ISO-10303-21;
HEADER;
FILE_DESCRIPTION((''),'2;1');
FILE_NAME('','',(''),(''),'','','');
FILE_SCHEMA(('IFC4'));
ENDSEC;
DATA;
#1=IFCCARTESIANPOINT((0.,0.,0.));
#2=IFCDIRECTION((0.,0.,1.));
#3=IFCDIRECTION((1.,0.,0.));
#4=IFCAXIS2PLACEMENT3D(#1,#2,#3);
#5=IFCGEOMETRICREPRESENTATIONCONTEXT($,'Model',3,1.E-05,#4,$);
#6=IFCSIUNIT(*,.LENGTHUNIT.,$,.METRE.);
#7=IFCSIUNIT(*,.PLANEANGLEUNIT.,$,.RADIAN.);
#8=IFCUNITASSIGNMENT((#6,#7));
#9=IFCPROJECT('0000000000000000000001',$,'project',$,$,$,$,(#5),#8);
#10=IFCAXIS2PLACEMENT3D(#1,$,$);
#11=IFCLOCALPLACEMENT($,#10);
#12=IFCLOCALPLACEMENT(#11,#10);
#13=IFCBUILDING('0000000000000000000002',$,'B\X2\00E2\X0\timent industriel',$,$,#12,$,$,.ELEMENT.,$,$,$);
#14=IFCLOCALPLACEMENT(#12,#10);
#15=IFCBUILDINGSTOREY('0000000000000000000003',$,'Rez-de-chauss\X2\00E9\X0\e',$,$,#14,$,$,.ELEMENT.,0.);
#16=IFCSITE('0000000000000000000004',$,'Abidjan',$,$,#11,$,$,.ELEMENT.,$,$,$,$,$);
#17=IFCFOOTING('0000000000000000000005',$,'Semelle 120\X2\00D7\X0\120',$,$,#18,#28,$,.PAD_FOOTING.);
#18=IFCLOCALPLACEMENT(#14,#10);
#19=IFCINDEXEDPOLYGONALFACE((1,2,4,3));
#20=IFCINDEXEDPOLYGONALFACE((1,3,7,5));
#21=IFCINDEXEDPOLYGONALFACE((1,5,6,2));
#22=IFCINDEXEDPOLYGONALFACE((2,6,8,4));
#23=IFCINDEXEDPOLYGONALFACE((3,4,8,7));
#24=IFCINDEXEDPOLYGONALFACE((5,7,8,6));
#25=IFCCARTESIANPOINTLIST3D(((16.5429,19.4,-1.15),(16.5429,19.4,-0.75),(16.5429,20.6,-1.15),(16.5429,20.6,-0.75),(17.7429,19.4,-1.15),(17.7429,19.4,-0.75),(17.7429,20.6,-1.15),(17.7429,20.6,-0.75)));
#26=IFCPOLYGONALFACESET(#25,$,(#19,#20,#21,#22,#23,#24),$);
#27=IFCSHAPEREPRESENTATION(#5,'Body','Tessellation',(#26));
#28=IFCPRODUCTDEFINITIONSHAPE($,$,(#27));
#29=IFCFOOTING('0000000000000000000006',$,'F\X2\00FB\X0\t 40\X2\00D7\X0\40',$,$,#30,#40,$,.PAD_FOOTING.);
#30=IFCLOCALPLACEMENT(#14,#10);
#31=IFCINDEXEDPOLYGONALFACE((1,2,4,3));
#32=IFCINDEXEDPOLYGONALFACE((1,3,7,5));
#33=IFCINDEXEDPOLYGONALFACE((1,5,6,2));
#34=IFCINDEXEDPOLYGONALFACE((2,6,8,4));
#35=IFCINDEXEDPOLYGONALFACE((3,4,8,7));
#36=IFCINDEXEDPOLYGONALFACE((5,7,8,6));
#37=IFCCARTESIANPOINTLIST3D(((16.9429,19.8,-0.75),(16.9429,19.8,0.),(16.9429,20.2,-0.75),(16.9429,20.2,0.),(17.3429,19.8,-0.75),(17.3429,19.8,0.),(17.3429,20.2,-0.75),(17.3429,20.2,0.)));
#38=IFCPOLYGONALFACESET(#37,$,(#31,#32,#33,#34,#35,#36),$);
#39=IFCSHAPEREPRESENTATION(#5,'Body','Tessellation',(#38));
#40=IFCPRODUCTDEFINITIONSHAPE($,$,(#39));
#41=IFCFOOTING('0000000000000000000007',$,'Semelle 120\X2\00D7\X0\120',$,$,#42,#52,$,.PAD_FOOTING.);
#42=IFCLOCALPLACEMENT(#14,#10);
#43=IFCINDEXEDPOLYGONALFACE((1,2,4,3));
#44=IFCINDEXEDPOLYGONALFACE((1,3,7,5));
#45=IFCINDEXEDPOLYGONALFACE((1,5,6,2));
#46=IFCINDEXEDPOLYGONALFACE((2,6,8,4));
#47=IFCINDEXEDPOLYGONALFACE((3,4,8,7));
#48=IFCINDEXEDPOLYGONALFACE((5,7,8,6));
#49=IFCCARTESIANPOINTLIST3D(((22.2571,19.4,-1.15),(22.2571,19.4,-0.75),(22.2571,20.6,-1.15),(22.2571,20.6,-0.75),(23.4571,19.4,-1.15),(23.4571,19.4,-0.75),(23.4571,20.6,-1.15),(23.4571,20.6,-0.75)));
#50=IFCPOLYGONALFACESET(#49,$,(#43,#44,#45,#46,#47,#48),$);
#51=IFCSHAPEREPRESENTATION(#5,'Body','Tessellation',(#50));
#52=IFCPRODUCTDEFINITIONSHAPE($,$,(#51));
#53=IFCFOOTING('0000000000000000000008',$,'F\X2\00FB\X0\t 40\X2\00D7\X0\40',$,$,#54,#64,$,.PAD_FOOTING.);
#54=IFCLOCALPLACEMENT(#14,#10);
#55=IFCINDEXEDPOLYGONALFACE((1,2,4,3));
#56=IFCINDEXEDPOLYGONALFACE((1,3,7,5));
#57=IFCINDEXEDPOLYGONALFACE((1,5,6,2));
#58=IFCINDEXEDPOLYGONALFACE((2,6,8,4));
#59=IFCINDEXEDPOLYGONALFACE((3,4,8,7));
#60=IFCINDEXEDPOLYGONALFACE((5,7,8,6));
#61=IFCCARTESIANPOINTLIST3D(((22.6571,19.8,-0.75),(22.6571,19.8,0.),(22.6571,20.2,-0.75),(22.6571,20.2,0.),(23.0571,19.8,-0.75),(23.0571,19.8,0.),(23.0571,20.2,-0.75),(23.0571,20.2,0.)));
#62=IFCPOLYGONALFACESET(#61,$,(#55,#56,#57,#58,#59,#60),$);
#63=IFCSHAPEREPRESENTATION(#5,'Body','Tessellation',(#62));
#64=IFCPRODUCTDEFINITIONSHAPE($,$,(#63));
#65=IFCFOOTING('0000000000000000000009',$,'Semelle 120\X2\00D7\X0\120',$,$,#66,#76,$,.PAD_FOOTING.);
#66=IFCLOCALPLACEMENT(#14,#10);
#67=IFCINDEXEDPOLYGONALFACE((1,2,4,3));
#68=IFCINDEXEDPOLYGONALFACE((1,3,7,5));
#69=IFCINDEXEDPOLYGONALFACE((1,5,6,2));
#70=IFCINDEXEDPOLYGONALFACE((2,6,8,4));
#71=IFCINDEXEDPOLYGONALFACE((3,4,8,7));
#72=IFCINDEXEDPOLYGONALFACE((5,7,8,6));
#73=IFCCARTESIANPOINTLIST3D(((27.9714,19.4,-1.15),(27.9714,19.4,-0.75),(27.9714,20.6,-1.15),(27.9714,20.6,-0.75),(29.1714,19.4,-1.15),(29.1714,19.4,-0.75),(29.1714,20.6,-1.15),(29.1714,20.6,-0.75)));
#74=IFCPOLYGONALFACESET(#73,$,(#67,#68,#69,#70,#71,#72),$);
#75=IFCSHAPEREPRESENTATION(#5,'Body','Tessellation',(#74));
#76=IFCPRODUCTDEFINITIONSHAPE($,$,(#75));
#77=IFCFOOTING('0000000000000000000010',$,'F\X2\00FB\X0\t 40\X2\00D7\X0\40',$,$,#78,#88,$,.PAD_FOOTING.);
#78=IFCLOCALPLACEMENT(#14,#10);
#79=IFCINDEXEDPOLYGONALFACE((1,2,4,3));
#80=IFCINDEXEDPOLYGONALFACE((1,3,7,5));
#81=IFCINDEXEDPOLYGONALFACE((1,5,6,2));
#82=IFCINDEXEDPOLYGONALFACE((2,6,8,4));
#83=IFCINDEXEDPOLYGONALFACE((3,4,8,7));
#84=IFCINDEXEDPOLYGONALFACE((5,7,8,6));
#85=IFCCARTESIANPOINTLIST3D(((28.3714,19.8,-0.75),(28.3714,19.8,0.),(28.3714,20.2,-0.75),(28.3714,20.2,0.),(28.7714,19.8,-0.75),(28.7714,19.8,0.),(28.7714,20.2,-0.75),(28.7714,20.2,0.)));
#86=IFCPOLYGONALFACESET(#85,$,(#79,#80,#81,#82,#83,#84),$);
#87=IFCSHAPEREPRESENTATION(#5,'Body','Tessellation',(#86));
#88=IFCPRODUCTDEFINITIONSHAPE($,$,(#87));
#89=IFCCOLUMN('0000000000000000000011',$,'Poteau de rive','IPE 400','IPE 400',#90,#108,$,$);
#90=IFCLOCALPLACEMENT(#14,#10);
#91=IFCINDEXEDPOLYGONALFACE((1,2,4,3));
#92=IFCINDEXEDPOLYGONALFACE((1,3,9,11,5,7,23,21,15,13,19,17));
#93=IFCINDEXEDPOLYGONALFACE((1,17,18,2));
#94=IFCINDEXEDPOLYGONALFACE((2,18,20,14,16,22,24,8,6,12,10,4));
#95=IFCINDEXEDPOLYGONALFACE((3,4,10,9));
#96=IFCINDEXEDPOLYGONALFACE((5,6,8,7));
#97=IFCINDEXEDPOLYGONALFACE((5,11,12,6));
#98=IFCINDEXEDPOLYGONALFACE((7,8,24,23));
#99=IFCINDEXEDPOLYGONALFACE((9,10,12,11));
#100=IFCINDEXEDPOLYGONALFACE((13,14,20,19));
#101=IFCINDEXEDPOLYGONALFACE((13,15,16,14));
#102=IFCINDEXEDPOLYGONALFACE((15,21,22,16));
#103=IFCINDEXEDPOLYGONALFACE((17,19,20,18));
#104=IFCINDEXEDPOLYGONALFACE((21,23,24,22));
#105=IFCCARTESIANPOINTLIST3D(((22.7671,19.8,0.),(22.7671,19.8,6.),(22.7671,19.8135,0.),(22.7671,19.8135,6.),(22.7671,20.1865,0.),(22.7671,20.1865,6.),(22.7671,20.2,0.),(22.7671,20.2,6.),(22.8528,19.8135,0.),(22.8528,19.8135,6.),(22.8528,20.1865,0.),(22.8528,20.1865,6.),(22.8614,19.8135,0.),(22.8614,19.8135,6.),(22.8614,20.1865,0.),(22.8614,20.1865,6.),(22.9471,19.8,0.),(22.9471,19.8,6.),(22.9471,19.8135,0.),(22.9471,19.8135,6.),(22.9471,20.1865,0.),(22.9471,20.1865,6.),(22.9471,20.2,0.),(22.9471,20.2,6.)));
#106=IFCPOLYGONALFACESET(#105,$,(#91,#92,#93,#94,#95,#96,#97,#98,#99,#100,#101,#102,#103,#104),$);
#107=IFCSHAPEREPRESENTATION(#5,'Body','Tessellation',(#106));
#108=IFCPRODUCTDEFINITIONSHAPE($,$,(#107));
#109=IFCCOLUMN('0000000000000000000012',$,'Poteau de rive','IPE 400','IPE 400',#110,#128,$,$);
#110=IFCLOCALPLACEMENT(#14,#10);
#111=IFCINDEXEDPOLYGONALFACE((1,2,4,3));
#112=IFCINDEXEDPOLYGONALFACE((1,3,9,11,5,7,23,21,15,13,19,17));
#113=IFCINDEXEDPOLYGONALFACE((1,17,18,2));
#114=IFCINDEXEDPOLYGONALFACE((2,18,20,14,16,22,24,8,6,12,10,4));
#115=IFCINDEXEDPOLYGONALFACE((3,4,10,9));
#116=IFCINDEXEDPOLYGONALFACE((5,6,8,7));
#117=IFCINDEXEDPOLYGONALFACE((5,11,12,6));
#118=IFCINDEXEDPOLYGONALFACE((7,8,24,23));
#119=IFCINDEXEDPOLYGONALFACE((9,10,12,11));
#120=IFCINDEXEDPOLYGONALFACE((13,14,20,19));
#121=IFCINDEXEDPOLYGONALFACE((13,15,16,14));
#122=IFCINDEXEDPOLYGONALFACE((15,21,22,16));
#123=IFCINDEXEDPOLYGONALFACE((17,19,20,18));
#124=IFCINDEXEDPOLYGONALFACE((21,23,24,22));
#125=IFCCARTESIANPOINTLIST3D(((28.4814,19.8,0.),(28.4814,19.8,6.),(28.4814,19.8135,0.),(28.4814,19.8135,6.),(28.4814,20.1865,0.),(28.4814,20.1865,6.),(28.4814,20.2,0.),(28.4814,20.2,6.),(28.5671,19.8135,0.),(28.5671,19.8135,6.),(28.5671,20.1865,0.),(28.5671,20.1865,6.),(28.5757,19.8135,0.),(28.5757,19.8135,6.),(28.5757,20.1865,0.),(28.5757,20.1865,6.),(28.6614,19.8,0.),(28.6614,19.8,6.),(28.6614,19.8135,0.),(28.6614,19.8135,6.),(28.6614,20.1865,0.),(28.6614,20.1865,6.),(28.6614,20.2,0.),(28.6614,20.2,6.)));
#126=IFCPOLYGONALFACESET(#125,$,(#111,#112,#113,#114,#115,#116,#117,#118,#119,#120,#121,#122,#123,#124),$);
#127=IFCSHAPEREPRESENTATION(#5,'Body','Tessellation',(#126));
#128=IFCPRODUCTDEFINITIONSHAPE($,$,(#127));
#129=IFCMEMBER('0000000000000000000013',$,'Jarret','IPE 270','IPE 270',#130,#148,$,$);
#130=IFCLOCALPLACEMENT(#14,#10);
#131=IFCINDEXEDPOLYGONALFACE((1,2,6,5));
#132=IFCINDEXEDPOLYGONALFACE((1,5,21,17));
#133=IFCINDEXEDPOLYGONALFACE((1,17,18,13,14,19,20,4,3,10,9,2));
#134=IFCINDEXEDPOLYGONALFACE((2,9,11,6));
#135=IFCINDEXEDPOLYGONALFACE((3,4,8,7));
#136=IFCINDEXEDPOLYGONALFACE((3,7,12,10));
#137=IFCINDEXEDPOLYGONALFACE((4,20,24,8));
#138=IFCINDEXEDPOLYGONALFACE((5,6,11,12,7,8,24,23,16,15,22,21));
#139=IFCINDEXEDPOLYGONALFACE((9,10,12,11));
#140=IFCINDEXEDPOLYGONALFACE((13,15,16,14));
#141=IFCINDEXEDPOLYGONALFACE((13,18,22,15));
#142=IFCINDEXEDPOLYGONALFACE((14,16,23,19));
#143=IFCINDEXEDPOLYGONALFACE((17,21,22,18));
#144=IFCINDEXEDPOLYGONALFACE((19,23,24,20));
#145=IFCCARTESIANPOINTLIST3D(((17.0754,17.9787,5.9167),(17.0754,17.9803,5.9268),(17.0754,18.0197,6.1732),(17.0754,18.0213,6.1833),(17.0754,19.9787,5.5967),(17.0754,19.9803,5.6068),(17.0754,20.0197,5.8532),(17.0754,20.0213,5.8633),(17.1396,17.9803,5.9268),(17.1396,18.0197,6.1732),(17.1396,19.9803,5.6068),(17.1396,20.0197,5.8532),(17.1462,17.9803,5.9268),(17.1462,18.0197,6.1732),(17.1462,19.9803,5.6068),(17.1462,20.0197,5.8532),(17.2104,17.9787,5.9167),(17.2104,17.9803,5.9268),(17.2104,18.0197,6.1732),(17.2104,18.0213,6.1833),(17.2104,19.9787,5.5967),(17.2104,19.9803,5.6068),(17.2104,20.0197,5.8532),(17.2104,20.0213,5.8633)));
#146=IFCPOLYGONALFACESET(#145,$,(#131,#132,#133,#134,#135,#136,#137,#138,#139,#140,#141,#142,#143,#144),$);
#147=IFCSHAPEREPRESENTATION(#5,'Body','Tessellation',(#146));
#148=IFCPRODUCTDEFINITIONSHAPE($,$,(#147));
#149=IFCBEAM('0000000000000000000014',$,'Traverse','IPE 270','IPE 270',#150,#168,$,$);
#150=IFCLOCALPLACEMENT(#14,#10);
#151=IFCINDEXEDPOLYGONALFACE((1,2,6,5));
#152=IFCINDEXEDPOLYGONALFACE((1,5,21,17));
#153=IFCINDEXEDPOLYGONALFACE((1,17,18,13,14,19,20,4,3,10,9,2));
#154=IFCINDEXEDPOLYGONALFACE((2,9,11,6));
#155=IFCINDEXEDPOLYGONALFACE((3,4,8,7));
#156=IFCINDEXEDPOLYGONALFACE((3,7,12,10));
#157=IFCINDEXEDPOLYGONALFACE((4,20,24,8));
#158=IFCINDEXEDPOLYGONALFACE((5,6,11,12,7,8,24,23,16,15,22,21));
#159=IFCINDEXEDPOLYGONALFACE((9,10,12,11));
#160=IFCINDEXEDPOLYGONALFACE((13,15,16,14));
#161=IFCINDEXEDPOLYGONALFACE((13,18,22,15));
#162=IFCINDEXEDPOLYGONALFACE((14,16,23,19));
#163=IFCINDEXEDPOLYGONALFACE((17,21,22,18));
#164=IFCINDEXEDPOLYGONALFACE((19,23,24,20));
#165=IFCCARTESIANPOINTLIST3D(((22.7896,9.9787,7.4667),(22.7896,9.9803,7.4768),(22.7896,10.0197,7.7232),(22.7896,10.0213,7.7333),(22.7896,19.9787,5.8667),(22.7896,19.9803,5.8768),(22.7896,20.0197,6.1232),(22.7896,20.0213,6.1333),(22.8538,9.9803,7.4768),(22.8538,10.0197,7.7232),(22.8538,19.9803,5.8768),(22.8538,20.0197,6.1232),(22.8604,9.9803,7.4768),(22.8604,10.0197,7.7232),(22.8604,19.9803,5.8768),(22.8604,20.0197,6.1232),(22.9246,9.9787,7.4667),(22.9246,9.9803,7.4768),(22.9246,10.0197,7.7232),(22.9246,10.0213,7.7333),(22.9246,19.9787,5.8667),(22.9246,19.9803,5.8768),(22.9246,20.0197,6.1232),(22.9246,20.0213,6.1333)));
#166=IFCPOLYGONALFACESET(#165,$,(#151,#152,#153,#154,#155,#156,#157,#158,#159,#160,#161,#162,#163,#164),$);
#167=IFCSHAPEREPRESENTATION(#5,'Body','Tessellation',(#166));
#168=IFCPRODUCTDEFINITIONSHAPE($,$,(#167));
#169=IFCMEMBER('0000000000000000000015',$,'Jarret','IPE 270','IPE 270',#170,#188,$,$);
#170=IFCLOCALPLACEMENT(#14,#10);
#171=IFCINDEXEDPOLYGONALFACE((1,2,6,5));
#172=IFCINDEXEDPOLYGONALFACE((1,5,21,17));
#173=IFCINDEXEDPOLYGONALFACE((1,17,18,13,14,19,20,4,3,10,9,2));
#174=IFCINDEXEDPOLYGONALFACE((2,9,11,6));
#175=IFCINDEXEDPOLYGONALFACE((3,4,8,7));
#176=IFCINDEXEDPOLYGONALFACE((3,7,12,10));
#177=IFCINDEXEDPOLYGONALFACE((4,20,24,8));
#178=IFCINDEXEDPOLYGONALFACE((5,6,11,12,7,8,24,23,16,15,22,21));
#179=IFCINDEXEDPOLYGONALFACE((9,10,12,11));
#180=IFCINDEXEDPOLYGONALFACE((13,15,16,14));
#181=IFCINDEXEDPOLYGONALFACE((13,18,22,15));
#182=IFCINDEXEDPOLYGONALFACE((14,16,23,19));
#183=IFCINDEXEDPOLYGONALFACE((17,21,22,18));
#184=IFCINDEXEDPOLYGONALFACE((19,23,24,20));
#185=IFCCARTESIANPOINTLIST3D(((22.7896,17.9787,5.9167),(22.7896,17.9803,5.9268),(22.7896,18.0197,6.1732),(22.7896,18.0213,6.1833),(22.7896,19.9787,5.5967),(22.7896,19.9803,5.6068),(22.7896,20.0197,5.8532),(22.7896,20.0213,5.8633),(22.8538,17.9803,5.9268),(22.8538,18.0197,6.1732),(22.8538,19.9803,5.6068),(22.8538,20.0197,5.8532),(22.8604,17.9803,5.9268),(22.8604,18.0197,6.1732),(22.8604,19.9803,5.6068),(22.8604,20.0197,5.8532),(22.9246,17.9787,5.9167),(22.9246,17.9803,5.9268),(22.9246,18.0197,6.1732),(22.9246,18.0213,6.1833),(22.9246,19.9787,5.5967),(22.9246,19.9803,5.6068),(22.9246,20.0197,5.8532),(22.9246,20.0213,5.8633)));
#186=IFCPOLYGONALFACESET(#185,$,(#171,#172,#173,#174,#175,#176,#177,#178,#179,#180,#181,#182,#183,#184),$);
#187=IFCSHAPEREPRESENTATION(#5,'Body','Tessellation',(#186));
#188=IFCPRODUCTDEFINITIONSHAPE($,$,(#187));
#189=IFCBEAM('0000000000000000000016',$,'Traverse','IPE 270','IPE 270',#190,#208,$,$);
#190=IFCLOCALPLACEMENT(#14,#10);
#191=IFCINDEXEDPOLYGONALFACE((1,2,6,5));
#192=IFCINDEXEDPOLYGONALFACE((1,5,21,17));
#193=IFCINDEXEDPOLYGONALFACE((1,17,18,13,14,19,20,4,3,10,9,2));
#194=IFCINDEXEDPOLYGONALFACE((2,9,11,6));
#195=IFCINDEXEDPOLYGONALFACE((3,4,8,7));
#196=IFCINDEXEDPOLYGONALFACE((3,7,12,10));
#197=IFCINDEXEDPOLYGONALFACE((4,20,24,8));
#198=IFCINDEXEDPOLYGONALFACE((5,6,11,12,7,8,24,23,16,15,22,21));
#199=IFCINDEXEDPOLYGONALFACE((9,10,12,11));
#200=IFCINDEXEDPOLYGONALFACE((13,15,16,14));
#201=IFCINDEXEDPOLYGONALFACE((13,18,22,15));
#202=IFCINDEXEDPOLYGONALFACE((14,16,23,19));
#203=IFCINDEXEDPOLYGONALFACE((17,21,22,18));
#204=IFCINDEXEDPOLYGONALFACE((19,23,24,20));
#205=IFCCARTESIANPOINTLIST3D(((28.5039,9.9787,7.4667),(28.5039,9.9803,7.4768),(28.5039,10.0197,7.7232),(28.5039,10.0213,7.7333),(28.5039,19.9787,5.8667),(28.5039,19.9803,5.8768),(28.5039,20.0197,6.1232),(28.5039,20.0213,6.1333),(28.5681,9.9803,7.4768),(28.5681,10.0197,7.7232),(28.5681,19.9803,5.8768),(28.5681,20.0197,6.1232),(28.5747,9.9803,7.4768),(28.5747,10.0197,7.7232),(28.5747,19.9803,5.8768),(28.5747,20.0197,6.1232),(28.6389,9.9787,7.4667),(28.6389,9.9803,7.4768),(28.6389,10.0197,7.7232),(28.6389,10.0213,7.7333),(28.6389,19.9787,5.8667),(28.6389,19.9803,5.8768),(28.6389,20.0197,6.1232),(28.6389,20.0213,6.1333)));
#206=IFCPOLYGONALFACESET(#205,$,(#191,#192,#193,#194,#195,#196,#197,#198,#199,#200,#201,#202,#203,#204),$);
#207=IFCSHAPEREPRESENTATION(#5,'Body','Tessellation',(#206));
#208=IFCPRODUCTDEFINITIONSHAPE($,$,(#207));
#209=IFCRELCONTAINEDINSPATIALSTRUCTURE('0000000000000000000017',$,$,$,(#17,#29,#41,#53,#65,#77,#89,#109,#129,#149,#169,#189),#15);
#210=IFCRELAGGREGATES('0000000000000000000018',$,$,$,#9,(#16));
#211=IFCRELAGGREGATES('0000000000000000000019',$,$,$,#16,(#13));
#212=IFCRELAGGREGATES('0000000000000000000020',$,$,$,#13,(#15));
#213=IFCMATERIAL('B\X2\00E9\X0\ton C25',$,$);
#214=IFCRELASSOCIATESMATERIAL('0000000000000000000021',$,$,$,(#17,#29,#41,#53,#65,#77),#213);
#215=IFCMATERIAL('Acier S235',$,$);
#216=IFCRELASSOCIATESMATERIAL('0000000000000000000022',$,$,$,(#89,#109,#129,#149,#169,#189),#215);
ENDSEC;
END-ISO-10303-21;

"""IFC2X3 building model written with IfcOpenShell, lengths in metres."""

from ifc_helpers import new_model, si_unit, frame, origin, origin_with_axes, origin_2d, place, context, project, spatial, rectangle, i_section, extrude, material, element, save


model = new_model("IFC2X3")

# Units and contexts
model_context = context("Model", 3, precision=1e-05, world=origin_with_axes())
ifc_project = project(units=[si_unit("LENGTHUNIT", "METRE"), si_unit("PLANEANGLEUNIT", "RADIAN")], contexts=[model_context])

# Site, building, storey
site_placement = place(None, origin())
site = spatial("IfcSite", under=ifc_project, at=site_placement, Name="Abidjan", CompositionType="ELEMENT")
building_placement = place(site_placement, origin())
building = spatial("IfcBuilding", under=site, at=building_placement, Name="Bâtiment industriel", CompositionType="ELEMENT")
storey_placement = place(building_placement, origin())
storey = spatial("IfcBuildingStorey", under=building, at=storey_placement, Name="Rez-de-chaussée", CompositionType="ELEMENT", Elevation=0.0)

# Footings
ifc_material_1 = material(Name="Béton C25")
footing_1_placement = place(storey_placement, frame((17.1429, 20.0, -1.15), z_axis=(0.0, 0.0, 1.0), x_axis=(1.0, 0.0, 0.0)))
element("IfcFooting", 1, at=footing_1_placement, inside=storey, material=ifc_material_1, Name="Semelle 120×120", PredefinedType="PAD_FOOTING", context=model_context, shape_type="SweptSolid", body=[
    extrude(rectangle(XDim=1.2, YDim=1.2, at=origin_2d()), origin(), (0.0, 0.0, 1.0), 0.4),
])
footing_2_placement = place(storey_placement, frame((17.1429, 20.0, -0.75), z_axis=(0.0, 0.0, 1.0), x_axis=(1.0, 0.0, 0.0)))
element("IfcFooting", 2, at=footing_2_placement, inside=storey, material=ifc_material_1, Name="Fût 40×40", PredefinedType="PAD_FOOTING", context=model_context, shape_type="SweptSolid", body=[
    extrude(rectangle(XDim=0.4, YDim=0.4, at=origin_2d()), origin(), (0.0, 0.0, 1.0), 0.75),
])
footing_3_placement = place(storey_placement, frame((22.8571, 20.0, -1.15), z_axis=(0.0, 0.0, 1.0), x_axis=(1.0, 0.0, 0.0)))
element("IfcFooting", 3, at=footing_3_placement, inside=storey, material=ifc_material_1, Name="Semelle 120×120", PredefinedType="PAD_FOOTING", context=model_context, shape_type="SweptSolid", body=[
    extrude(rectangle(XDim=1.2, YDim=1.2, at=origin_2d()), origin(), (0.0, 0.0, 1.0), 0.4),
])
footing_4_placement = place(storey_placement, frame((22.8571, 20.0, -0.75), z_axis=(0.0, 0.0, 1.0), x_axis=(1.0, 0.0, 0.0)))
element("IfcFooting", 4, at=footing_4_placement, inside=storey, material=ifc_material_1, Name="Fût 40×40", PredefinedType="PAD_FOOTING", context=model_context, shape_type="SweptSolid", body=[
    extrude(rectangle(XDim=0.4, YDim=0.4, at=origin_2d()), origin(), (0.0, 0.0, 1.0), 0.75),
])
footing_5_placement = place(storey_placement, frame((28.5714, 20.0, -1.15), z_axis=(0.0, 0.0, 1.0), x_axis=(1.0, 0.0, 0.0)))
element("IfcFooting", 5, at=footing_5_placement, inside=storey, material=ifc_material_1, Name="Semelle 120×120", PredefinedType="PAD_FOOTING", context=model_context, shape_type="SweptSolid", body=[
    extrude(rectangle(XDim=1.2, YDim=1.2, at=origin_2d()), origin(), (0.0, 0.0, 1.0), 0.4),
])
footing_6_placement = place(storey_placement, frame((28.5714, 20.0, -0.75), z_axis=(0.0, 0.0, 1.0), x_axis=(1.0, 0.0, 0.0)))
element("IfcFooting", 6, at=footing_6_placement, inside=storey, material=ifc_material_1, Name="Fût 40×40", PredefinedType="PAD_FOOTING", context=model_context, shape_type="SweptSolid", body=[
    extrude(rectangle(XDim=0.4, YDim=0.4, at=origin_2d()), origin(), (0.0, 0.0, 1.0), 0.75),
])

# Columns
ifc_material_2 = material(Name="Acier S235")
for number, where, z_axis, x_axis, name in (
    (7, (22.8571, 20.0, 0.0), (0.0, 0.0, 1.0), (1.0, 0.0, 0.0), "Poteau de rive"),
    (8, (28.5714, 20.0, 0.0), (0.0, 0.0, 1.0), (1.0, 0.0, 0.0), "Poteau de rive"),
):
    element("IfcColumn", number, at=place(storey_placement, frame(where, z_axis=z_axis, x_axis=x_axis)), inside=storey, material=ifc_material_2, Name=name, Description="IPE 400", ObjectType="IPE 400", context=model_context, shape_type="SweptSolid", body=[
        extrude(i_section(OverallWidth=0.18, OverallDepth=0.4, WebThickness=0.0086, FlangeThickness=0.0135, at=origin_2d()), origin(), (0.0, 0.0, 1.0), 6.0),
    ])

# Member
member_1_placement = place(storey_placement, frame((17.1429, 20.0, 5.73), z_axis=(0.0, -0.98744, 0.15799), x_axis=(1.0, 0.0, 0.0)))
element("IfcMember", 9, at=member_1_placement, inside=storey, material=ifc_material_2, Name="Jarret", Description="IPE 270", ObjectType="IPE 270", context=model_context, shape_type="SweptSolid", body=[
    extrude(i_section(OverallWidth=0.135, OverallDepth=0.27, WebThickness=0.0066, FlangeThickness=0.0102, at=origin_2d()), origin(), (0.0, 0.0, 1.0), 2.0254),
])

# Beam
beam_1_placement = place(storey_placement, frame((22.8571, 10.0, 7.6), z_axis=(0.0, 0.98744, -0.15799), x_axis=(1.0, 0.0, 0.0)))
element("IfcBeam", 10, at=beam_1_placement, inside=storey, material=ifc_material_2, Name="Traverse", Description="IPE 270", ObjectType="IPE 270", context=model_context, shape_type="SweptSolid", body=[
    extrude(i_section(OverallWidth=0.135, OverallDepth=0.27, WebThickness=0.0066, FlangeThickness=0.0102, at=origin_2d()), origin(), (0.0, 0.0, 1.0), 10.1272),
])

# Member
member_2_placement = place(storey_placement, frame((22.8571, 20.0, 5.73), z_axis=(0.0, -0.98744, 0.15799), x_axis=(1.0, 0.0, 0.0)))
element("IfcMember", 11, at=member_2_placement, inside=storey, material=ifc_material_2, Name="Jarret", Description="IPE 270", ObjectType="IPE 270", context=model_context, shape_type="SweptSolid", body=[
    extrude(i_section(OverallWidth=0.135, OverallDepth=0.27, WebThickness=0.0066, FlangeThickness=0.0102, at=origin_2d()), origin(), (0.0, 0.0, 1.0), 2.0254),
])

# Beam
beam_2_placement = place(storey_placement, frame((28.5714, 10.0, 7.6), z_axis=(0.0, 0.98744, -0.15799), x_axis=(1.0, 0.0, 0.0)))
element("IfcBeam", 12, at=beam_2_placement, inside=storey, material=ifc_material_2, Name="Traverse", Description="IPE 270", ObjectType="IPE 270", context=model_context, shape_type="SweptSolid", body=[
    extrude(i_section(OverallWidth=0.135, OverallDepth=0.27, WebThickness=0.0066, FlangeThickness=0.0102, at=origin_2d()), origin(), (0.0, 0.0, 1.0), 10.1272),
])

save(model, "model.ifc")
